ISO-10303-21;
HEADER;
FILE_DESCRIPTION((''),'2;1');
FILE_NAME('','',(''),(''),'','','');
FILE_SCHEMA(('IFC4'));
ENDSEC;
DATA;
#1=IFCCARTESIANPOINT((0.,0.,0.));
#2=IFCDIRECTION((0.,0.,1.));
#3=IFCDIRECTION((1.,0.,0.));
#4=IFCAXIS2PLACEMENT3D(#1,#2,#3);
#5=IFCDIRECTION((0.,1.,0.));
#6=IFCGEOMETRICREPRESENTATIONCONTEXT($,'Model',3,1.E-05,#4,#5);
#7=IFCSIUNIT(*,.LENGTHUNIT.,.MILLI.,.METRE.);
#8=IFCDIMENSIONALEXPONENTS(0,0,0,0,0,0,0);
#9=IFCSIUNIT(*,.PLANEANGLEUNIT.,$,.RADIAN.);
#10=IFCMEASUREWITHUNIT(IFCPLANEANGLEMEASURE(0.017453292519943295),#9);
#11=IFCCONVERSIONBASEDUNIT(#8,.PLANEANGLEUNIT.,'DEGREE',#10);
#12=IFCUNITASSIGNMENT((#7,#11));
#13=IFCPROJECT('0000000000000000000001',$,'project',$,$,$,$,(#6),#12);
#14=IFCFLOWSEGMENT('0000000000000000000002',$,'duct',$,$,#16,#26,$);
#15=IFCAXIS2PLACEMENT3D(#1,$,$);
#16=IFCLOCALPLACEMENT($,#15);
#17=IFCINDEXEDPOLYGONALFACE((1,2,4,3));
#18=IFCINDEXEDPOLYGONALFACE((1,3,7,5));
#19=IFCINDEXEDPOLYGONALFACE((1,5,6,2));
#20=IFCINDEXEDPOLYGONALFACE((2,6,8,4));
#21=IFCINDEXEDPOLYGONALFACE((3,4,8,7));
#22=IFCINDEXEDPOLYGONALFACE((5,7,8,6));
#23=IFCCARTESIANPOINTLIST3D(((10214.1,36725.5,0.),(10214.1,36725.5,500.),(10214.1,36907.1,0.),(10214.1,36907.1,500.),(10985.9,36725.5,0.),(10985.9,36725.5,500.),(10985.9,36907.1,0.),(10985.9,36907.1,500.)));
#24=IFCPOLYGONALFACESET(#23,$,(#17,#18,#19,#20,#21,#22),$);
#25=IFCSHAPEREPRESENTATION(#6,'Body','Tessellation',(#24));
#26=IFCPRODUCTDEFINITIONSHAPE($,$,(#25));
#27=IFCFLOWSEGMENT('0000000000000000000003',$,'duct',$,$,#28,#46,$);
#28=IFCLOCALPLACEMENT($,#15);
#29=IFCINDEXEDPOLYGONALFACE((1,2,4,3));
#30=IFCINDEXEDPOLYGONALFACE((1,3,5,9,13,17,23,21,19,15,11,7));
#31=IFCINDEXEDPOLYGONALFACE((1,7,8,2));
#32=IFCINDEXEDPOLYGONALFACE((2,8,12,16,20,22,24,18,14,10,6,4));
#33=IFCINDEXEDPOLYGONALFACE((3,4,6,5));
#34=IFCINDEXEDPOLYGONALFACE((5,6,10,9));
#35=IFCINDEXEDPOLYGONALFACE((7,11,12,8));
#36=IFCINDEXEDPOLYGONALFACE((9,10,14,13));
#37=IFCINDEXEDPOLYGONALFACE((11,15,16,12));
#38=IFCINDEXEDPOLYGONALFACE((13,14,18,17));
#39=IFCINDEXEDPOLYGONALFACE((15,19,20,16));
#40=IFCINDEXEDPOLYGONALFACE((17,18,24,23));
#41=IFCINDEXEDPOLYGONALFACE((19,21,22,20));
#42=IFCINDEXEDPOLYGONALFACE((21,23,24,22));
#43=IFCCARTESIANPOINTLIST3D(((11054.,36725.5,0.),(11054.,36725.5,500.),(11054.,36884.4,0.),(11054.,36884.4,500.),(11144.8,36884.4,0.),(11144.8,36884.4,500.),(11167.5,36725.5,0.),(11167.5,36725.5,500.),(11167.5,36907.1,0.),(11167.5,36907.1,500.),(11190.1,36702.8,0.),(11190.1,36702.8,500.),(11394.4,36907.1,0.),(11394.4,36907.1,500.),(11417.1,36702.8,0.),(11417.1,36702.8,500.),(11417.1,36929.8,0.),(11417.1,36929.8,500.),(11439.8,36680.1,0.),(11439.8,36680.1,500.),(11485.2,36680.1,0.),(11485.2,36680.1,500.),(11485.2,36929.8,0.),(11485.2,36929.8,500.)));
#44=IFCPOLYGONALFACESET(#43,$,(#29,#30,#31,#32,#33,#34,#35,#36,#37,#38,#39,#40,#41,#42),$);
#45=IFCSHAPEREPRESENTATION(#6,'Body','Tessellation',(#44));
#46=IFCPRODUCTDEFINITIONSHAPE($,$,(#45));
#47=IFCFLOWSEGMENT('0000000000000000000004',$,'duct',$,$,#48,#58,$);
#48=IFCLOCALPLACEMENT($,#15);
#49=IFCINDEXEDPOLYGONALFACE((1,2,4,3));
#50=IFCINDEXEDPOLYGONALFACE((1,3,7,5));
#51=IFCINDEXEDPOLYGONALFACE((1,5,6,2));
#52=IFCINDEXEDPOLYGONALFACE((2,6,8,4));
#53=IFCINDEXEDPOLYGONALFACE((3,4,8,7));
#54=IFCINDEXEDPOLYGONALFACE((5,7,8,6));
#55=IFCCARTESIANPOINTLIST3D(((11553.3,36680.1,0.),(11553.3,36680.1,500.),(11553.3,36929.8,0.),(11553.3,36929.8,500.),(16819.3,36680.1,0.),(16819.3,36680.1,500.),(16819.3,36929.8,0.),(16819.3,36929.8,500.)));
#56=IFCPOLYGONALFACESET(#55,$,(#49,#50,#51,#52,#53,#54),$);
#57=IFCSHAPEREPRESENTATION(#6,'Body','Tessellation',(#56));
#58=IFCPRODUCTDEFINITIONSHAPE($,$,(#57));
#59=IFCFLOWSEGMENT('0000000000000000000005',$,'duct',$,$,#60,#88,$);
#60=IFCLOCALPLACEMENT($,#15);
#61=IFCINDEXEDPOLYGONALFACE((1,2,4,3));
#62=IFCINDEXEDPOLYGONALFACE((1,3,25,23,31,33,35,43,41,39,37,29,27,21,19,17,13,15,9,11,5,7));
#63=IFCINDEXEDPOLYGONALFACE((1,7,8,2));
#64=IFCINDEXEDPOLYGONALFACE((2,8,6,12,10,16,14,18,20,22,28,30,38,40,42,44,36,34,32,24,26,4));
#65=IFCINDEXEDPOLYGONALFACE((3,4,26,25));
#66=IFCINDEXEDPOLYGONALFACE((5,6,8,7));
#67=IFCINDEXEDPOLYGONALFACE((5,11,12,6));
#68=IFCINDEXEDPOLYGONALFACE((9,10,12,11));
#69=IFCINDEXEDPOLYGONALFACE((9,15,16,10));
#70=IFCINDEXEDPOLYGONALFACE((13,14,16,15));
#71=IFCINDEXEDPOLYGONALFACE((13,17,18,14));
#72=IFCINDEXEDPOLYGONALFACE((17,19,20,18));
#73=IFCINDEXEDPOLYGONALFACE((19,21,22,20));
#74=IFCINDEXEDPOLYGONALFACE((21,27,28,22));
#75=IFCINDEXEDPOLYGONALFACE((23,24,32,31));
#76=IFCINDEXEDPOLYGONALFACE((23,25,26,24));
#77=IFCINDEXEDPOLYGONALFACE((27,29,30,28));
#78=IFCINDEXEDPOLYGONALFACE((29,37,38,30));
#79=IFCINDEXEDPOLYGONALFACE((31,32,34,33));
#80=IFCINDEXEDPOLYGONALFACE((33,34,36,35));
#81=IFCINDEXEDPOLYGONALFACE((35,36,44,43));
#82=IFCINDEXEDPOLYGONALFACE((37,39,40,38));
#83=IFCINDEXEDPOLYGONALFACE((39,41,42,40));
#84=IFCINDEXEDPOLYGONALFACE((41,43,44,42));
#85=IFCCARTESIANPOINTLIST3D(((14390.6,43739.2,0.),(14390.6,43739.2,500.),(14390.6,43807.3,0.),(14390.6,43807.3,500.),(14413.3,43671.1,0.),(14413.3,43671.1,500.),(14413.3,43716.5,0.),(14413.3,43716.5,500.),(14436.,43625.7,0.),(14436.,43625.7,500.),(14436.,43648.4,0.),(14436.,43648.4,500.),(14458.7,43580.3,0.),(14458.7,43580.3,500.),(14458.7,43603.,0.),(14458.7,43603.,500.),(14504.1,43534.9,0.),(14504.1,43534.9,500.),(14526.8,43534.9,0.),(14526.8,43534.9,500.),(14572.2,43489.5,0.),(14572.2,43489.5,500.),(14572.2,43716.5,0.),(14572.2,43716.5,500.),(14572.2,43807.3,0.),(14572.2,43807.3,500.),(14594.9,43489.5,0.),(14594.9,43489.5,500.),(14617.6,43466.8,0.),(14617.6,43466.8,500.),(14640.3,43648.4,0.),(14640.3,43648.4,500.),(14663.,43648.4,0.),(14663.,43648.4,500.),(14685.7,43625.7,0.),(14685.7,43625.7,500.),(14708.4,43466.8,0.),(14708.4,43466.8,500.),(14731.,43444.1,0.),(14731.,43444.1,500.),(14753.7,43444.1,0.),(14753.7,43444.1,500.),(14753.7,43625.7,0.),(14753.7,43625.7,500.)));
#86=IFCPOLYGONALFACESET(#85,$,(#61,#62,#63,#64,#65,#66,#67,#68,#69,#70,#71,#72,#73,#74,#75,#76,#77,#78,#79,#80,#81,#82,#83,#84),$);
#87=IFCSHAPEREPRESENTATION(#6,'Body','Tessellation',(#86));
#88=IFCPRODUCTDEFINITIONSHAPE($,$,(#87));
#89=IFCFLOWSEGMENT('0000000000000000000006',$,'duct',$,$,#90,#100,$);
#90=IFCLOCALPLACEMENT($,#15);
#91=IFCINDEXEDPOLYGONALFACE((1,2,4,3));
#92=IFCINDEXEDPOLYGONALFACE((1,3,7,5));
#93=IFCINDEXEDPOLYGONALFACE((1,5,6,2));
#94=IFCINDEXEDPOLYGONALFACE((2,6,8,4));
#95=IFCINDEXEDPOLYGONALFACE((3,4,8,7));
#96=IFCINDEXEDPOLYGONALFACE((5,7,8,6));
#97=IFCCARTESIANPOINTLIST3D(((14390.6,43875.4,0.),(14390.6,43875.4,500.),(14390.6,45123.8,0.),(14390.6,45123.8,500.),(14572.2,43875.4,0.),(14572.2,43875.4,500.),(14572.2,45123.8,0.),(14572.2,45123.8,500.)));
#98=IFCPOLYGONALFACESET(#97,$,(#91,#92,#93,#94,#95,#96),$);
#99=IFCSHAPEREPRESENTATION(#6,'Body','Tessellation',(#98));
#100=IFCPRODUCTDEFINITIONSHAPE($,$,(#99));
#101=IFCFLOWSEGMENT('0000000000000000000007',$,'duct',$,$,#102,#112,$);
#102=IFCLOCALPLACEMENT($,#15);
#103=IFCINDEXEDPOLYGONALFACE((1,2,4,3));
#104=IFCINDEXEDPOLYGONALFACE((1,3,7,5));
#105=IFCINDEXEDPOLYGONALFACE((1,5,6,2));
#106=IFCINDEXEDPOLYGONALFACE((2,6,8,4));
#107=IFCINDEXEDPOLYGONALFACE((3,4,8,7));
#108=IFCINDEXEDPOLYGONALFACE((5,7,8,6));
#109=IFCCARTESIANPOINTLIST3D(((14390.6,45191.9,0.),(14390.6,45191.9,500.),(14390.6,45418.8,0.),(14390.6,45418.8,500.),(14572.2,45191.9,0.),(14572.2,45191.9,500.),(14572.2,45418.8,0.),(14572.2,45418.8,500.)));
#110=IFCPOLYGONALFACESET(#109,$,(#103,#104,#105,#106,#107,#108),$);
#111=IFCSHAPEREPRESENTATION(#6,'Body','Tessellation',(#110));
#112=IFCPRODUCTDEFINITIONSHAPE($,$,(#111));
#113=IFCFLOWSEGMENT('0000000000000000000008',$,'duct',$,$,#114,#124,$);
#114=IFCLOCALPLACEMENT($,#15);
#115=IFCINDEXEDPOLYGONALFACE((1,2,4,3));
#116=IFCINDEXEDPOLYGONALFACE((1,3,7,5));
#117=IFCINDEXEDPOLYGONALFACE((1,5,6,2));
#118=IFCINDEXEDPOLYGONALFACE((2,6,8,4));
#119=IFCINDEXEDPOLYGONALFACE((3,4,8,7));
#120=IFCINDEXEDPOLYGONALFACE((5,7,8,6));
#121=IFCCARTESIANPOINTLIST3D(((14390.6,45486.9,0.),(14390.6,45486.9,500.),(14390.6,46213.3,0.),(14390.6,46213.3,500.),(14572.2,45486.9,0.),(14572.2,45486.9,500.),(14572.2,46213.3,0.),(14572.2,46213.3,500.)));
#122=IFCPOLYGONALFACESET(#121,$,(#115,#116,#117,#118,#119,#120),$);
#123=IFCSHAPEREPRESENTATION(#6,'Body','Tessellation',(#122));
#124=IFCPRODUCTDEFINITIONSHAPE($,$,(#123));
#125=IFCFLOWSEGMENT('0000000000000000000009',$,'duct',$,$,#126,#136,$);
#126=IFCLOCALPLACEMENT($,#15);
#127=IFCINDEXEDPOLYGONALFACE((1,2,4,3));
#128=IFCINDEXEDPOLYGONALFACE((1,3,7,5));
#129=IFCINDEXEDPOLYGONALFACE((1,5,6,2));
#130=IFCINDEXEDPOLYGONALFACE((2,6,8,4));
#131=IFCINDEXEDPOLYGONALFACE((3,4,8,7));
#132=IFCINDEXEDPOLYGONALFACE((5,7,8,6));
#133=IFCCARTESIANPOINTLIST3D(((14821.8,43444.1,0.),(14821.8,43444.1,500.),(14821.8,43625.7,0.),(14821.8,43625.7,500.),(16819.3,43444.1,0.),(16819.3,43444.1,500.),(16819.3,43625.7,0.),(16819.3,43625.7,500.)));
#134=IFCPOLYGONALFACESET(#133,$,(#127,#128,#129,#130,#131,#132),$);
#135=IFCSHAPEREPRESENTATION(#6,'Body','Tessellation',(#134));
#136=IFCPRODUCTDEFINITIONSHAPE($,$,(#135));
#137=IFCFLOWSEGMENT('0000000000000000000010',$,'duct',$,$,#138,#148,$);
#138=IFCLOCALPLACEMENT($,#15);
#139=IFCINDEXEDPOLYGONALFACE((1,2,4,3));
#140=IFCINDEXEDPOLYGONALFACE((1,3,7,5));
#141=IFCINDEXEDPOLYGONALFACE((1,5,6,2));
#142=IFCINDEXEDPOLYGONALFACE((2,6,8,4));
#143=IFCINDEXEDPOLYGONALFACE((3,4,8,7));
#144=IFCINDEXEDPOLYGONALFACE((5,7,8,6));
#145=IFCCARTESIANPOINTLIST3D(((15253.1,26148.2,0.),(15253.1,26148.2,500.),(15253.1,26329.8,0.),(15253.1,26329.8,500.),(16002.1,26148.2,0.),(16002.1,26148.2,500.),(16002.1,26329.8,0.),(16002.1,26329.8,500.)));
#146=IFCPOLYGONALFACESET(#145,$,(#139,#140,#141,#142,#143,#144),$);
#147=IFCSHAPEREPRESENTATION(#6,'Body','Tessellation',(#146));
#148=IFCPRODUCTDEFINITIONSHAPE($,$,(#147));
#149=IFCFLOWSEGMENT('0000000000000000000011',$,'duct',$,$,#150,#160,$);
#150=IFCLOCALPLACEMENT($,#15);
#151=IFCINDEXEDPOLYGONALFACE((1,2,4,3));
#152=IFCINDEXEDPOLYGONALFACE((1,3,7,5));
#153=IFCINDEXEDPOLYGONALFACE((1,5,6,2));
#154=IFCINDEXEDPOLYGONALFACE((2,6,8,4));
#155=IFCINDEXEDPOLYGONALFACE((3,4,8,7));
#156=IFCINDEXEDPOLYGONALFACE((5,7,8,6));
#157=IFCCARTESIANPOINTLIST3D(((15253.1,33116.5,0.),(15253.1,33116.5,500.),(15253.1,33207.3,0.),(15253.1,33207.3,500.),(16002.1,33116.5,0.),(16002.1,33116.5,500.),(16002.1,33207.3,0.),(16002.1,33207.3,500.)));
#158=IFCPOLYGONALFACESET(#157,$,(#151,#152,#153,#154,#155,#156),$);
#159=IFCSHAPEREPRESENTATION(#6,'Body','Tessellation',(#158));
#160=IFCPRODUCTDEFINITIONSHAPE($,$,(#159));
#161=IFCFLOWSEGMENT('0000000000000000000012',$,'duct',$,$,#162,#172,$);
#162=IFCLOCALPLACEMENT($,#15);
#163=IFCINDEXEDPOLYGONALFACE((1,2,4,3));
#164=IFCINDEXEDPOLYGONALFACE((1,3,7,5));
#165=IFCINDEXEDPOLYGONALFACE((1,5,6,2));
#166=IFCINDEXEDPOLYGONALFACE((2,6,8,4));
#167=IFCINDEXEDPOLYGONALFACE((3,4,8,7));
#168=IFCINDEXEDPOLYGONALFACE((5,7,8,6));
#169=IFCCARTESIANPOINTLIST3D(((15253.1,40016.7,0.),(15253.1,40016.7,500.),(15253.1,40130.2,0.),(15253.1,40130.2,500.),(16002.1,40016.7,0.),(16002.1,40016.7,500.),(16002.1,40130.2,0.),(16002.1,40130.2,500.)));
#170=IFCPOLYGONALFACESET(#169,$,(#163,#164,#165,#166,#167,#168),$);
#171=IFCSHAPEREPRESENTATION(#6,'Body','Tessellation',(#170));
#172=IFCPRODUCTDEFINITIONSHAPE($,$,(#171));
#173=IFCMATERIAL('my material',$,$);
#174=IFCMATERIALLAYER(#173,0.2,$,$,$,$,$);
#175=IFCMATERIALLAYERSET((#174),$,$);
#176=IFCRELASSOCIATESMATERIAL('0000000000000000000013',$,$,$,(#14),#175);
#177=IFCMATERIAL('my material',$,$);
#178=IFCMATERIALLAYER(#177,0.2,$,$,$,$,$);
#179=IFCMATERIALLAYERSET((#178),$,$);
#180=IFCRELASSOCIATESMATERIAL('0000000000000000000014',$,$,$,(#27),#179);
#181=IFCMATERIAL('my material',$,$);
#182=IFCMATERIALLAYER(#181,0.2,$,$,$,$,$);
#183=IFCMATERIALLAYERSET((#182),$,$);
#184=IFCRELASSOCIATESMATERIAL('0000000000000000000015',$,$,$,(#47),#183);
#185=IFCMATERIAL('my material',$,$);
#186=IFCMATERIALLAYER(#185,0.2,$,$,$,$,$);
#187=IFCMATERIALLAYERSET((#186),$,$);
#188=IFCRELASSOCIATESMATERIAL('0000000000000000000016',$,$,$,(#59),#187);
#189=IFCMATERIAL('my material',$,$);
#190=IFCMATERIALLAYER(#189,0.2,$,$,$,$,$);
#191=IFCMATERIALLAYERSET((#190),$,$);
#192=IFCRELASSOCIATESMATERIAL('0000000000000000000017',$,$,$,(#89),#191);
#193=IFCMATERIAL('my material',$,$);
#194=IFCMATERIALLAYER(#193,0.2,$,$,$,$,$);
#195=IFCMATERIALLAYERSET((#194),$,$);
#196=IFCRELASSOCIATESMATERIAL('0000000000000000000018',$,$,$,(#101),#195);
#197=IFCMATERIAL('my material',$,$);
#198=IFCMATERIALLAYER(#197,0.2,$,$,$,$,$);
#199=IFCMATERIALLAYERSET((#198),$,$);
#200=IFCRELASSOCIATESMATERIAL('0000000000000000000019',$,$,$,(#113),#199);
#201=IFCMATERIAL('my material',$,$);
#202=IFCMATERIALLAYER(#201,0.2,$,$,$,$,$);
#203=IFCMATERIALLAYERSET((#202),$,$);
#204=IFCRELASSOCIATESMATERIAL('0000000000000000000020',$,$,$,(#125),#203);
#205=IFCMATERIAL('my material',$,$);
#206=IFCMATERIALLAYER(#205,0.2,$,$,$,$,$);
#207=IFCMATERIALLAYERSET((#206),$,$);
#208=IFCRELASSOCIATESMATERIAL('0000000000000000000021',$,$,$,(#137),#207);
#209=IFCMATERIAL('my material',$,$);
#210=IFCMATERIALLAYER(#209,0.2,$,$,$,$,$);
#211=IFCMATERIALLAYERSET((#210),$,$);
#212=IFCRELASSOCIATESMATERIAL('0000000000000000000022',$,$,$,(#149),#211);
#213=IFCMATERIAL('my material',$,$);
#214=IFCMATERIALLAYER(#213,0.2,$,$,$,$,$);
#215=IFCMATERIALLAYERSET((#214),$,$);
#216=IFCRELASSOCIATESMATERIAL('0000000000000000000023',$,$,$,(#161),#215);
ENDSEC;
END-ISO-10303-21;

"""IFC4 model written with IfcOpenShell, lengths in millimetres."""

from ifc_helpers import new_model, entity, si_unit, converted_unit, direction, origin_with_axes, place, context, project, polyline, outline, extrude, material, layer, layer_set, layer_usage, element, save


model = new_model("IFC4")

# Units and contexts
model_context = context("Model", 3, precision=1e-05, world=origin_with_axes(), true_north=direction((0.0, 1.0, 0.0)))
ifc_project = project(units=[si_unit("LENGTHUNIT", "METRE", prefix="MILLI"), converted_unit("PLANEANGLEUNIT", "DEGREE", entity("IfcPlaneAngleMeasure", 0.017453292519943295), si_unit("PLANEANGLEUNIT", "RADIAN"), dimensions=[0, 0, 0, 0, 0, 0, 0])], contexts=[model_context])

# Flow segments
ifc_material_1 = material(Name="my material")
ifc_layer_1 = layer(ifc_material_1, 0.2)
ifc_layer_set_1 = layer_set([ifc_layer_1])
ifc_layer_usage_1 = layer_usage(ifc_layer_set_1, "AXIS2", "POSITIVE", -0.1)
flow_segment_1_placement = place(None, origin_with_axes())
element("IfcFlowSegment", 1, at=flow_segment_1_placement, material=ifc_layer_usage_1, Name="duct", context=model_context, shape_type="SweptSolid", body=[
    extrude(outline(polyline([(10214.1, 36725.5), (10985.9, 36725.5), (10985.9, 36907.1), (10214.1, 36907.1), (10214.1, 36725.5)])), origin_with_axes(), (0.0, 0.0, 1.0), 500.0),
])
ifc_material_2 = material(Name="my material")
ifc_layer_2 = layer(ifc_material_2, 0.2)
ifc_layer_set_2 = layer_set([ifc_layer_2])
ifc_layer_usage_2 = layer_usage(ifc_layer_set_2, "AXIS2", "POSITIVE", -0.1)
flow_segment_2_placement = place(None, origin_with_axes())
element("IfcFlowSegment", 2, at=flow_segment_2_placement, material=ifc_layer_usage_2, Name="duct", context=model_context, shape_type="SweptSolid", body=[
    extrude(outline(polyline([(11054.0, 36725.5), (11167.5, 36725.5), (11190.1, 36702.8), (11417.1, 36702.8), (11439.8, 36680.1), (11485.2, 36680.1), (11485.2, 36929.8), (11417.1, 36929.8), (11394.4, 36907.1), (11167.5, 36907.1), (11144.8, 36884.4), (11054.0, 36884.4), (11054.0, 36725.5)])), origin_with_axes(), (0.0, 0.0, 1.0), 500.0),
])
ifc_material_3 = material(Name="my material")
ifc_layer_3 = layer(ifc_material_3, 0.2)
ifc_layer_set_3 = layer_set([ifc_layer_3])
ifc_layer_usage_3 = layer_usage(ifc_layer_set_3, "AXIS2", "POSITIVE", -0.1)
flow_segment_3_placement = place(None, origin_with_axes())
element("IfcFlowSegment", 3, at=flow_segment_3_placement, material=ifc_layer_usage_3, Name="duct", context=model_context, shape_type="SweptSolid", body=[
    extrude(outline(polyline([(11553.3, 36680.1), (16819.3, 36680.1), (16819.3, 36929.8), (11553.3, 36929.8), (11553.3, 36680.1)])), origin_with_axes(), (0.0, 0.0, 1.0), 500.0),
])
ifc_material_4 = material(Name="my material")
ifc_layer_4 = layer(ifc_material_4, 0.2)
ifc_layer_set_4 = layer_set([ifc_layer_4])
ifc_layer_usage_4 = layer_usage(ifc_layer_set_4, "AXIS2", "POSITIVE", -0.1)
flow_segment_4_placement = place(None, origin_with_axes())
element("IfcFlowSegment", 4, at=flow_segment_4_placement, material=ifc_layer_usage_4, Name="duct", context=model_context, shape_type="SweptSolid", body=[
    extrude(outline(polyline([(14390.6, 43739.2), (14413.3, 43716.5), (14413.3, 43671.1), (14436.0, 43648.4), (14436.0, 43625.7), (14458.7, 43603.0), (14458.7, 43580.3), (14504.1, 43534.9), (14526.8, 43534.9), (14572.2, 43489.5), (14594.9, 43489.5), (14617.6, 43466.8), (14708.4, 43466.8), (14731.0, 43444.1), (14753.7, 43444.1), (14753.7, 43625.7), (14685.7, 43625.7), (14663.0, 43648.4), (14640.3, 43648.4), (14572.2, 43716.5), (14572.2, 43807.3), (14390.6, 43807.3), (14390.6, 43739.2)])), origin_with_axes(), (0.0, 0.0, 1.0), 500.0),
])
ifc_material_5 = material(Name="my material")
ifc_layer_5 = layer(ifc_material_5, 0.2)
ifc_layer_set_5 = layer_set([ifc_layer_5])
ifc_layer_usage_5 = layer_usage(ifc_layer_set_5, "AXIS2", "POSITIVE", -0.1)
flow_segment_5_placement = place(None, origin_with_axes())
element("IfcFlowSegment", 5, at=flow_segment_5_placement, material=ifc_layer_usage_5, Name="duct", context=model_context, shape_type="SweptSolid", body=[
    extrude(outline(polyline([(14390.6, 43875.4), (14572.2, 43875.4), (14572.2, 45123.8), (14390.6, 45123.8), (14390.6, 43875.4)])), origin_with_axes(), (0.0, 0.0, 1.0), 500.0),
])
ifc_material_6 = material(Name="my material")
ifc_layer_6 = layer(ifc_material_6, 0.2)
ifc_layer_set_6 = layer_set([ifc_layer_6])
ifc_layer_usage_6 = layer_usage(ifc_layer_set_6, "AXIS2", "POSITIVE", -0.1)
flow_segment_6_placement = place(None, origin_with_axes())
element("IfcFlowSegment", 6, at=flow_segment_6_placement, material=ifc_layer_usage_6, Name="duct", context=model_context, shape_type="SweptSolid", body=[
    extrude(outline(polyline([(14390.6, 45191.9), (14572.2, 45191.9), (14572.2, 45418.8), (14390.6, 45418.8), (14390.6, 45191.9)])), origin_with_axes(), (0.0, 0.0, 1.0), 500.0),
])
ifc_material_7 = material(Name="my material")
ifc_layer_7 = layer(ifc_material_7, 0.2)
ifc_layer_set_7 = layer_set([ifc_layer_7])
ifc_layer_usage_7 = layer_usage(ifc_layer_set_7, "AXIS2", "POSITIVE", -0.1)
flow_segment_7_placement = place(None, origin_with_axes())
element("IfcFlowSegment", 7, at=flow_segment_7_placement, material=ifc_layer_usage_7, Name="duct", context=model_context, shape_type="SweptSolid", body=[
    extrude(outline(polyline([(14390.6, 45486.9), (14572.2, 45486.9), (14572.2, 46213.3), (14390.6, 46213.3), (14390.6, 45486.9)])), origin_with_axes(), (0.0, 0.0, 1.0), 500.0),
])
ifc_material_8 = material(Name="my material")
ifc_layer_8 = layer(ifc_material_8, 0.2)
ifc_layer_set_8 = layer_set([ifc_layer_8])
ifc_layer_usage_8 = layer_usage(ifc_layer_set_8, "AXIS2", "POSITIVE", -0.1)
flow_segment_8_placement = place(None, origin_with_axes())
element("IfcFlowSegment", 8, at=flow_segment_8_placement, material=ifc_layer_usage_8, Name="duct", context=model_context, shape_type="SweptSolid", body=[
    extrude(outline(polyline([(14821.8, 43444.1), (16819.3, 43444.1), (16819.3, 43625.7), (14821.8, 43625.7), (14821.8, 43444.1)])), origin_with_axes(), (0.0, 0.0, 1.0), 500.0),
])
ifc_material_9 = material(Name="my material")
ifc_layer_9 = layer(ifc_material_9, 0.2)
ifc_layer_set_9 = layer_set([ifc_layer_9])
ifc_layer_usage_9 = layer_usage(ifc_layer_set_9, "AXIS2", "POSITIVE", -0.1)
flow_segment_9_placement = place(None, origin_with_axes())
element("IfcFlowSegment", 9, at=flow_segment_9_placement, material=ifc_layer_usage_9, Name="duct", context=model_context, shape_type="SweptSolid", body=[
    extrude(outline(polyline([(15253.1, 26148.2), (16002.1, 26148.2), (16002.1, 26329.8), (15253.1, 26329.8), (15253.1, 26148.2)])), origin_with_axes(), (0.0, 0.0, 1.0), 500.0),
])
ifc_material_10 = material(Name="my material")
ifc_layer_10 = layer(ifc_material_10, 0.2)
ifc_layer_set_10 = layer_set([ifc_layer_10])
ifc_layer_usage_10 = layer_usage(ifc_layer_set_10, "AXIS2", "POSITIVE", -0.1)
flow_segment_10_placement = place(None, origin_with_axes())
element("IfcFlowSegment", 10, at=flow_segment_10_placement, material=ifc_layer_usage_10, Name="duct", context=model_context, shape_type="SweptSolid", body=[
    extrude(outline(polyline([(15253.1, 33116.5), (16002.1, 33116.5), (16002.1, 33207.3), (15253.1, 33207.3), (15253.1, 33116.5)])), origin_with_axes(), (0.0, 0.0, 1.0), 500.0),
])
ifc_material_11 = material(Name="my material")
ifc_layer_11 = layer(ifc_material_11, 0.2)
ifc_layer_set_11 = layer_set([ifc_layer_11])
ifc_layer_usage_11 = layer_usage(ifc_layer_set_11, "AXIS2", "POSITIVE", -0.1)
flow_segment_11_placement = place(None, origin_with_axes())
element("IfcFlowSegment", 11, at=flow_segment_11_placement, material=ifc_layer_usage_11, Name="duct", context=model_context, shape_type="SweptSolid", body=[
    extrude(outline(polyline([(15253.1, 40016.7), (16002.1, 40016.7), (16002.1, 40130.2), (15253.1, 40130.2), (15253.1, 40016.7)])), origin_with_axes(), (0.0, 0.0, 1.0), 500.0),
])

save(model, "model.ifc")
